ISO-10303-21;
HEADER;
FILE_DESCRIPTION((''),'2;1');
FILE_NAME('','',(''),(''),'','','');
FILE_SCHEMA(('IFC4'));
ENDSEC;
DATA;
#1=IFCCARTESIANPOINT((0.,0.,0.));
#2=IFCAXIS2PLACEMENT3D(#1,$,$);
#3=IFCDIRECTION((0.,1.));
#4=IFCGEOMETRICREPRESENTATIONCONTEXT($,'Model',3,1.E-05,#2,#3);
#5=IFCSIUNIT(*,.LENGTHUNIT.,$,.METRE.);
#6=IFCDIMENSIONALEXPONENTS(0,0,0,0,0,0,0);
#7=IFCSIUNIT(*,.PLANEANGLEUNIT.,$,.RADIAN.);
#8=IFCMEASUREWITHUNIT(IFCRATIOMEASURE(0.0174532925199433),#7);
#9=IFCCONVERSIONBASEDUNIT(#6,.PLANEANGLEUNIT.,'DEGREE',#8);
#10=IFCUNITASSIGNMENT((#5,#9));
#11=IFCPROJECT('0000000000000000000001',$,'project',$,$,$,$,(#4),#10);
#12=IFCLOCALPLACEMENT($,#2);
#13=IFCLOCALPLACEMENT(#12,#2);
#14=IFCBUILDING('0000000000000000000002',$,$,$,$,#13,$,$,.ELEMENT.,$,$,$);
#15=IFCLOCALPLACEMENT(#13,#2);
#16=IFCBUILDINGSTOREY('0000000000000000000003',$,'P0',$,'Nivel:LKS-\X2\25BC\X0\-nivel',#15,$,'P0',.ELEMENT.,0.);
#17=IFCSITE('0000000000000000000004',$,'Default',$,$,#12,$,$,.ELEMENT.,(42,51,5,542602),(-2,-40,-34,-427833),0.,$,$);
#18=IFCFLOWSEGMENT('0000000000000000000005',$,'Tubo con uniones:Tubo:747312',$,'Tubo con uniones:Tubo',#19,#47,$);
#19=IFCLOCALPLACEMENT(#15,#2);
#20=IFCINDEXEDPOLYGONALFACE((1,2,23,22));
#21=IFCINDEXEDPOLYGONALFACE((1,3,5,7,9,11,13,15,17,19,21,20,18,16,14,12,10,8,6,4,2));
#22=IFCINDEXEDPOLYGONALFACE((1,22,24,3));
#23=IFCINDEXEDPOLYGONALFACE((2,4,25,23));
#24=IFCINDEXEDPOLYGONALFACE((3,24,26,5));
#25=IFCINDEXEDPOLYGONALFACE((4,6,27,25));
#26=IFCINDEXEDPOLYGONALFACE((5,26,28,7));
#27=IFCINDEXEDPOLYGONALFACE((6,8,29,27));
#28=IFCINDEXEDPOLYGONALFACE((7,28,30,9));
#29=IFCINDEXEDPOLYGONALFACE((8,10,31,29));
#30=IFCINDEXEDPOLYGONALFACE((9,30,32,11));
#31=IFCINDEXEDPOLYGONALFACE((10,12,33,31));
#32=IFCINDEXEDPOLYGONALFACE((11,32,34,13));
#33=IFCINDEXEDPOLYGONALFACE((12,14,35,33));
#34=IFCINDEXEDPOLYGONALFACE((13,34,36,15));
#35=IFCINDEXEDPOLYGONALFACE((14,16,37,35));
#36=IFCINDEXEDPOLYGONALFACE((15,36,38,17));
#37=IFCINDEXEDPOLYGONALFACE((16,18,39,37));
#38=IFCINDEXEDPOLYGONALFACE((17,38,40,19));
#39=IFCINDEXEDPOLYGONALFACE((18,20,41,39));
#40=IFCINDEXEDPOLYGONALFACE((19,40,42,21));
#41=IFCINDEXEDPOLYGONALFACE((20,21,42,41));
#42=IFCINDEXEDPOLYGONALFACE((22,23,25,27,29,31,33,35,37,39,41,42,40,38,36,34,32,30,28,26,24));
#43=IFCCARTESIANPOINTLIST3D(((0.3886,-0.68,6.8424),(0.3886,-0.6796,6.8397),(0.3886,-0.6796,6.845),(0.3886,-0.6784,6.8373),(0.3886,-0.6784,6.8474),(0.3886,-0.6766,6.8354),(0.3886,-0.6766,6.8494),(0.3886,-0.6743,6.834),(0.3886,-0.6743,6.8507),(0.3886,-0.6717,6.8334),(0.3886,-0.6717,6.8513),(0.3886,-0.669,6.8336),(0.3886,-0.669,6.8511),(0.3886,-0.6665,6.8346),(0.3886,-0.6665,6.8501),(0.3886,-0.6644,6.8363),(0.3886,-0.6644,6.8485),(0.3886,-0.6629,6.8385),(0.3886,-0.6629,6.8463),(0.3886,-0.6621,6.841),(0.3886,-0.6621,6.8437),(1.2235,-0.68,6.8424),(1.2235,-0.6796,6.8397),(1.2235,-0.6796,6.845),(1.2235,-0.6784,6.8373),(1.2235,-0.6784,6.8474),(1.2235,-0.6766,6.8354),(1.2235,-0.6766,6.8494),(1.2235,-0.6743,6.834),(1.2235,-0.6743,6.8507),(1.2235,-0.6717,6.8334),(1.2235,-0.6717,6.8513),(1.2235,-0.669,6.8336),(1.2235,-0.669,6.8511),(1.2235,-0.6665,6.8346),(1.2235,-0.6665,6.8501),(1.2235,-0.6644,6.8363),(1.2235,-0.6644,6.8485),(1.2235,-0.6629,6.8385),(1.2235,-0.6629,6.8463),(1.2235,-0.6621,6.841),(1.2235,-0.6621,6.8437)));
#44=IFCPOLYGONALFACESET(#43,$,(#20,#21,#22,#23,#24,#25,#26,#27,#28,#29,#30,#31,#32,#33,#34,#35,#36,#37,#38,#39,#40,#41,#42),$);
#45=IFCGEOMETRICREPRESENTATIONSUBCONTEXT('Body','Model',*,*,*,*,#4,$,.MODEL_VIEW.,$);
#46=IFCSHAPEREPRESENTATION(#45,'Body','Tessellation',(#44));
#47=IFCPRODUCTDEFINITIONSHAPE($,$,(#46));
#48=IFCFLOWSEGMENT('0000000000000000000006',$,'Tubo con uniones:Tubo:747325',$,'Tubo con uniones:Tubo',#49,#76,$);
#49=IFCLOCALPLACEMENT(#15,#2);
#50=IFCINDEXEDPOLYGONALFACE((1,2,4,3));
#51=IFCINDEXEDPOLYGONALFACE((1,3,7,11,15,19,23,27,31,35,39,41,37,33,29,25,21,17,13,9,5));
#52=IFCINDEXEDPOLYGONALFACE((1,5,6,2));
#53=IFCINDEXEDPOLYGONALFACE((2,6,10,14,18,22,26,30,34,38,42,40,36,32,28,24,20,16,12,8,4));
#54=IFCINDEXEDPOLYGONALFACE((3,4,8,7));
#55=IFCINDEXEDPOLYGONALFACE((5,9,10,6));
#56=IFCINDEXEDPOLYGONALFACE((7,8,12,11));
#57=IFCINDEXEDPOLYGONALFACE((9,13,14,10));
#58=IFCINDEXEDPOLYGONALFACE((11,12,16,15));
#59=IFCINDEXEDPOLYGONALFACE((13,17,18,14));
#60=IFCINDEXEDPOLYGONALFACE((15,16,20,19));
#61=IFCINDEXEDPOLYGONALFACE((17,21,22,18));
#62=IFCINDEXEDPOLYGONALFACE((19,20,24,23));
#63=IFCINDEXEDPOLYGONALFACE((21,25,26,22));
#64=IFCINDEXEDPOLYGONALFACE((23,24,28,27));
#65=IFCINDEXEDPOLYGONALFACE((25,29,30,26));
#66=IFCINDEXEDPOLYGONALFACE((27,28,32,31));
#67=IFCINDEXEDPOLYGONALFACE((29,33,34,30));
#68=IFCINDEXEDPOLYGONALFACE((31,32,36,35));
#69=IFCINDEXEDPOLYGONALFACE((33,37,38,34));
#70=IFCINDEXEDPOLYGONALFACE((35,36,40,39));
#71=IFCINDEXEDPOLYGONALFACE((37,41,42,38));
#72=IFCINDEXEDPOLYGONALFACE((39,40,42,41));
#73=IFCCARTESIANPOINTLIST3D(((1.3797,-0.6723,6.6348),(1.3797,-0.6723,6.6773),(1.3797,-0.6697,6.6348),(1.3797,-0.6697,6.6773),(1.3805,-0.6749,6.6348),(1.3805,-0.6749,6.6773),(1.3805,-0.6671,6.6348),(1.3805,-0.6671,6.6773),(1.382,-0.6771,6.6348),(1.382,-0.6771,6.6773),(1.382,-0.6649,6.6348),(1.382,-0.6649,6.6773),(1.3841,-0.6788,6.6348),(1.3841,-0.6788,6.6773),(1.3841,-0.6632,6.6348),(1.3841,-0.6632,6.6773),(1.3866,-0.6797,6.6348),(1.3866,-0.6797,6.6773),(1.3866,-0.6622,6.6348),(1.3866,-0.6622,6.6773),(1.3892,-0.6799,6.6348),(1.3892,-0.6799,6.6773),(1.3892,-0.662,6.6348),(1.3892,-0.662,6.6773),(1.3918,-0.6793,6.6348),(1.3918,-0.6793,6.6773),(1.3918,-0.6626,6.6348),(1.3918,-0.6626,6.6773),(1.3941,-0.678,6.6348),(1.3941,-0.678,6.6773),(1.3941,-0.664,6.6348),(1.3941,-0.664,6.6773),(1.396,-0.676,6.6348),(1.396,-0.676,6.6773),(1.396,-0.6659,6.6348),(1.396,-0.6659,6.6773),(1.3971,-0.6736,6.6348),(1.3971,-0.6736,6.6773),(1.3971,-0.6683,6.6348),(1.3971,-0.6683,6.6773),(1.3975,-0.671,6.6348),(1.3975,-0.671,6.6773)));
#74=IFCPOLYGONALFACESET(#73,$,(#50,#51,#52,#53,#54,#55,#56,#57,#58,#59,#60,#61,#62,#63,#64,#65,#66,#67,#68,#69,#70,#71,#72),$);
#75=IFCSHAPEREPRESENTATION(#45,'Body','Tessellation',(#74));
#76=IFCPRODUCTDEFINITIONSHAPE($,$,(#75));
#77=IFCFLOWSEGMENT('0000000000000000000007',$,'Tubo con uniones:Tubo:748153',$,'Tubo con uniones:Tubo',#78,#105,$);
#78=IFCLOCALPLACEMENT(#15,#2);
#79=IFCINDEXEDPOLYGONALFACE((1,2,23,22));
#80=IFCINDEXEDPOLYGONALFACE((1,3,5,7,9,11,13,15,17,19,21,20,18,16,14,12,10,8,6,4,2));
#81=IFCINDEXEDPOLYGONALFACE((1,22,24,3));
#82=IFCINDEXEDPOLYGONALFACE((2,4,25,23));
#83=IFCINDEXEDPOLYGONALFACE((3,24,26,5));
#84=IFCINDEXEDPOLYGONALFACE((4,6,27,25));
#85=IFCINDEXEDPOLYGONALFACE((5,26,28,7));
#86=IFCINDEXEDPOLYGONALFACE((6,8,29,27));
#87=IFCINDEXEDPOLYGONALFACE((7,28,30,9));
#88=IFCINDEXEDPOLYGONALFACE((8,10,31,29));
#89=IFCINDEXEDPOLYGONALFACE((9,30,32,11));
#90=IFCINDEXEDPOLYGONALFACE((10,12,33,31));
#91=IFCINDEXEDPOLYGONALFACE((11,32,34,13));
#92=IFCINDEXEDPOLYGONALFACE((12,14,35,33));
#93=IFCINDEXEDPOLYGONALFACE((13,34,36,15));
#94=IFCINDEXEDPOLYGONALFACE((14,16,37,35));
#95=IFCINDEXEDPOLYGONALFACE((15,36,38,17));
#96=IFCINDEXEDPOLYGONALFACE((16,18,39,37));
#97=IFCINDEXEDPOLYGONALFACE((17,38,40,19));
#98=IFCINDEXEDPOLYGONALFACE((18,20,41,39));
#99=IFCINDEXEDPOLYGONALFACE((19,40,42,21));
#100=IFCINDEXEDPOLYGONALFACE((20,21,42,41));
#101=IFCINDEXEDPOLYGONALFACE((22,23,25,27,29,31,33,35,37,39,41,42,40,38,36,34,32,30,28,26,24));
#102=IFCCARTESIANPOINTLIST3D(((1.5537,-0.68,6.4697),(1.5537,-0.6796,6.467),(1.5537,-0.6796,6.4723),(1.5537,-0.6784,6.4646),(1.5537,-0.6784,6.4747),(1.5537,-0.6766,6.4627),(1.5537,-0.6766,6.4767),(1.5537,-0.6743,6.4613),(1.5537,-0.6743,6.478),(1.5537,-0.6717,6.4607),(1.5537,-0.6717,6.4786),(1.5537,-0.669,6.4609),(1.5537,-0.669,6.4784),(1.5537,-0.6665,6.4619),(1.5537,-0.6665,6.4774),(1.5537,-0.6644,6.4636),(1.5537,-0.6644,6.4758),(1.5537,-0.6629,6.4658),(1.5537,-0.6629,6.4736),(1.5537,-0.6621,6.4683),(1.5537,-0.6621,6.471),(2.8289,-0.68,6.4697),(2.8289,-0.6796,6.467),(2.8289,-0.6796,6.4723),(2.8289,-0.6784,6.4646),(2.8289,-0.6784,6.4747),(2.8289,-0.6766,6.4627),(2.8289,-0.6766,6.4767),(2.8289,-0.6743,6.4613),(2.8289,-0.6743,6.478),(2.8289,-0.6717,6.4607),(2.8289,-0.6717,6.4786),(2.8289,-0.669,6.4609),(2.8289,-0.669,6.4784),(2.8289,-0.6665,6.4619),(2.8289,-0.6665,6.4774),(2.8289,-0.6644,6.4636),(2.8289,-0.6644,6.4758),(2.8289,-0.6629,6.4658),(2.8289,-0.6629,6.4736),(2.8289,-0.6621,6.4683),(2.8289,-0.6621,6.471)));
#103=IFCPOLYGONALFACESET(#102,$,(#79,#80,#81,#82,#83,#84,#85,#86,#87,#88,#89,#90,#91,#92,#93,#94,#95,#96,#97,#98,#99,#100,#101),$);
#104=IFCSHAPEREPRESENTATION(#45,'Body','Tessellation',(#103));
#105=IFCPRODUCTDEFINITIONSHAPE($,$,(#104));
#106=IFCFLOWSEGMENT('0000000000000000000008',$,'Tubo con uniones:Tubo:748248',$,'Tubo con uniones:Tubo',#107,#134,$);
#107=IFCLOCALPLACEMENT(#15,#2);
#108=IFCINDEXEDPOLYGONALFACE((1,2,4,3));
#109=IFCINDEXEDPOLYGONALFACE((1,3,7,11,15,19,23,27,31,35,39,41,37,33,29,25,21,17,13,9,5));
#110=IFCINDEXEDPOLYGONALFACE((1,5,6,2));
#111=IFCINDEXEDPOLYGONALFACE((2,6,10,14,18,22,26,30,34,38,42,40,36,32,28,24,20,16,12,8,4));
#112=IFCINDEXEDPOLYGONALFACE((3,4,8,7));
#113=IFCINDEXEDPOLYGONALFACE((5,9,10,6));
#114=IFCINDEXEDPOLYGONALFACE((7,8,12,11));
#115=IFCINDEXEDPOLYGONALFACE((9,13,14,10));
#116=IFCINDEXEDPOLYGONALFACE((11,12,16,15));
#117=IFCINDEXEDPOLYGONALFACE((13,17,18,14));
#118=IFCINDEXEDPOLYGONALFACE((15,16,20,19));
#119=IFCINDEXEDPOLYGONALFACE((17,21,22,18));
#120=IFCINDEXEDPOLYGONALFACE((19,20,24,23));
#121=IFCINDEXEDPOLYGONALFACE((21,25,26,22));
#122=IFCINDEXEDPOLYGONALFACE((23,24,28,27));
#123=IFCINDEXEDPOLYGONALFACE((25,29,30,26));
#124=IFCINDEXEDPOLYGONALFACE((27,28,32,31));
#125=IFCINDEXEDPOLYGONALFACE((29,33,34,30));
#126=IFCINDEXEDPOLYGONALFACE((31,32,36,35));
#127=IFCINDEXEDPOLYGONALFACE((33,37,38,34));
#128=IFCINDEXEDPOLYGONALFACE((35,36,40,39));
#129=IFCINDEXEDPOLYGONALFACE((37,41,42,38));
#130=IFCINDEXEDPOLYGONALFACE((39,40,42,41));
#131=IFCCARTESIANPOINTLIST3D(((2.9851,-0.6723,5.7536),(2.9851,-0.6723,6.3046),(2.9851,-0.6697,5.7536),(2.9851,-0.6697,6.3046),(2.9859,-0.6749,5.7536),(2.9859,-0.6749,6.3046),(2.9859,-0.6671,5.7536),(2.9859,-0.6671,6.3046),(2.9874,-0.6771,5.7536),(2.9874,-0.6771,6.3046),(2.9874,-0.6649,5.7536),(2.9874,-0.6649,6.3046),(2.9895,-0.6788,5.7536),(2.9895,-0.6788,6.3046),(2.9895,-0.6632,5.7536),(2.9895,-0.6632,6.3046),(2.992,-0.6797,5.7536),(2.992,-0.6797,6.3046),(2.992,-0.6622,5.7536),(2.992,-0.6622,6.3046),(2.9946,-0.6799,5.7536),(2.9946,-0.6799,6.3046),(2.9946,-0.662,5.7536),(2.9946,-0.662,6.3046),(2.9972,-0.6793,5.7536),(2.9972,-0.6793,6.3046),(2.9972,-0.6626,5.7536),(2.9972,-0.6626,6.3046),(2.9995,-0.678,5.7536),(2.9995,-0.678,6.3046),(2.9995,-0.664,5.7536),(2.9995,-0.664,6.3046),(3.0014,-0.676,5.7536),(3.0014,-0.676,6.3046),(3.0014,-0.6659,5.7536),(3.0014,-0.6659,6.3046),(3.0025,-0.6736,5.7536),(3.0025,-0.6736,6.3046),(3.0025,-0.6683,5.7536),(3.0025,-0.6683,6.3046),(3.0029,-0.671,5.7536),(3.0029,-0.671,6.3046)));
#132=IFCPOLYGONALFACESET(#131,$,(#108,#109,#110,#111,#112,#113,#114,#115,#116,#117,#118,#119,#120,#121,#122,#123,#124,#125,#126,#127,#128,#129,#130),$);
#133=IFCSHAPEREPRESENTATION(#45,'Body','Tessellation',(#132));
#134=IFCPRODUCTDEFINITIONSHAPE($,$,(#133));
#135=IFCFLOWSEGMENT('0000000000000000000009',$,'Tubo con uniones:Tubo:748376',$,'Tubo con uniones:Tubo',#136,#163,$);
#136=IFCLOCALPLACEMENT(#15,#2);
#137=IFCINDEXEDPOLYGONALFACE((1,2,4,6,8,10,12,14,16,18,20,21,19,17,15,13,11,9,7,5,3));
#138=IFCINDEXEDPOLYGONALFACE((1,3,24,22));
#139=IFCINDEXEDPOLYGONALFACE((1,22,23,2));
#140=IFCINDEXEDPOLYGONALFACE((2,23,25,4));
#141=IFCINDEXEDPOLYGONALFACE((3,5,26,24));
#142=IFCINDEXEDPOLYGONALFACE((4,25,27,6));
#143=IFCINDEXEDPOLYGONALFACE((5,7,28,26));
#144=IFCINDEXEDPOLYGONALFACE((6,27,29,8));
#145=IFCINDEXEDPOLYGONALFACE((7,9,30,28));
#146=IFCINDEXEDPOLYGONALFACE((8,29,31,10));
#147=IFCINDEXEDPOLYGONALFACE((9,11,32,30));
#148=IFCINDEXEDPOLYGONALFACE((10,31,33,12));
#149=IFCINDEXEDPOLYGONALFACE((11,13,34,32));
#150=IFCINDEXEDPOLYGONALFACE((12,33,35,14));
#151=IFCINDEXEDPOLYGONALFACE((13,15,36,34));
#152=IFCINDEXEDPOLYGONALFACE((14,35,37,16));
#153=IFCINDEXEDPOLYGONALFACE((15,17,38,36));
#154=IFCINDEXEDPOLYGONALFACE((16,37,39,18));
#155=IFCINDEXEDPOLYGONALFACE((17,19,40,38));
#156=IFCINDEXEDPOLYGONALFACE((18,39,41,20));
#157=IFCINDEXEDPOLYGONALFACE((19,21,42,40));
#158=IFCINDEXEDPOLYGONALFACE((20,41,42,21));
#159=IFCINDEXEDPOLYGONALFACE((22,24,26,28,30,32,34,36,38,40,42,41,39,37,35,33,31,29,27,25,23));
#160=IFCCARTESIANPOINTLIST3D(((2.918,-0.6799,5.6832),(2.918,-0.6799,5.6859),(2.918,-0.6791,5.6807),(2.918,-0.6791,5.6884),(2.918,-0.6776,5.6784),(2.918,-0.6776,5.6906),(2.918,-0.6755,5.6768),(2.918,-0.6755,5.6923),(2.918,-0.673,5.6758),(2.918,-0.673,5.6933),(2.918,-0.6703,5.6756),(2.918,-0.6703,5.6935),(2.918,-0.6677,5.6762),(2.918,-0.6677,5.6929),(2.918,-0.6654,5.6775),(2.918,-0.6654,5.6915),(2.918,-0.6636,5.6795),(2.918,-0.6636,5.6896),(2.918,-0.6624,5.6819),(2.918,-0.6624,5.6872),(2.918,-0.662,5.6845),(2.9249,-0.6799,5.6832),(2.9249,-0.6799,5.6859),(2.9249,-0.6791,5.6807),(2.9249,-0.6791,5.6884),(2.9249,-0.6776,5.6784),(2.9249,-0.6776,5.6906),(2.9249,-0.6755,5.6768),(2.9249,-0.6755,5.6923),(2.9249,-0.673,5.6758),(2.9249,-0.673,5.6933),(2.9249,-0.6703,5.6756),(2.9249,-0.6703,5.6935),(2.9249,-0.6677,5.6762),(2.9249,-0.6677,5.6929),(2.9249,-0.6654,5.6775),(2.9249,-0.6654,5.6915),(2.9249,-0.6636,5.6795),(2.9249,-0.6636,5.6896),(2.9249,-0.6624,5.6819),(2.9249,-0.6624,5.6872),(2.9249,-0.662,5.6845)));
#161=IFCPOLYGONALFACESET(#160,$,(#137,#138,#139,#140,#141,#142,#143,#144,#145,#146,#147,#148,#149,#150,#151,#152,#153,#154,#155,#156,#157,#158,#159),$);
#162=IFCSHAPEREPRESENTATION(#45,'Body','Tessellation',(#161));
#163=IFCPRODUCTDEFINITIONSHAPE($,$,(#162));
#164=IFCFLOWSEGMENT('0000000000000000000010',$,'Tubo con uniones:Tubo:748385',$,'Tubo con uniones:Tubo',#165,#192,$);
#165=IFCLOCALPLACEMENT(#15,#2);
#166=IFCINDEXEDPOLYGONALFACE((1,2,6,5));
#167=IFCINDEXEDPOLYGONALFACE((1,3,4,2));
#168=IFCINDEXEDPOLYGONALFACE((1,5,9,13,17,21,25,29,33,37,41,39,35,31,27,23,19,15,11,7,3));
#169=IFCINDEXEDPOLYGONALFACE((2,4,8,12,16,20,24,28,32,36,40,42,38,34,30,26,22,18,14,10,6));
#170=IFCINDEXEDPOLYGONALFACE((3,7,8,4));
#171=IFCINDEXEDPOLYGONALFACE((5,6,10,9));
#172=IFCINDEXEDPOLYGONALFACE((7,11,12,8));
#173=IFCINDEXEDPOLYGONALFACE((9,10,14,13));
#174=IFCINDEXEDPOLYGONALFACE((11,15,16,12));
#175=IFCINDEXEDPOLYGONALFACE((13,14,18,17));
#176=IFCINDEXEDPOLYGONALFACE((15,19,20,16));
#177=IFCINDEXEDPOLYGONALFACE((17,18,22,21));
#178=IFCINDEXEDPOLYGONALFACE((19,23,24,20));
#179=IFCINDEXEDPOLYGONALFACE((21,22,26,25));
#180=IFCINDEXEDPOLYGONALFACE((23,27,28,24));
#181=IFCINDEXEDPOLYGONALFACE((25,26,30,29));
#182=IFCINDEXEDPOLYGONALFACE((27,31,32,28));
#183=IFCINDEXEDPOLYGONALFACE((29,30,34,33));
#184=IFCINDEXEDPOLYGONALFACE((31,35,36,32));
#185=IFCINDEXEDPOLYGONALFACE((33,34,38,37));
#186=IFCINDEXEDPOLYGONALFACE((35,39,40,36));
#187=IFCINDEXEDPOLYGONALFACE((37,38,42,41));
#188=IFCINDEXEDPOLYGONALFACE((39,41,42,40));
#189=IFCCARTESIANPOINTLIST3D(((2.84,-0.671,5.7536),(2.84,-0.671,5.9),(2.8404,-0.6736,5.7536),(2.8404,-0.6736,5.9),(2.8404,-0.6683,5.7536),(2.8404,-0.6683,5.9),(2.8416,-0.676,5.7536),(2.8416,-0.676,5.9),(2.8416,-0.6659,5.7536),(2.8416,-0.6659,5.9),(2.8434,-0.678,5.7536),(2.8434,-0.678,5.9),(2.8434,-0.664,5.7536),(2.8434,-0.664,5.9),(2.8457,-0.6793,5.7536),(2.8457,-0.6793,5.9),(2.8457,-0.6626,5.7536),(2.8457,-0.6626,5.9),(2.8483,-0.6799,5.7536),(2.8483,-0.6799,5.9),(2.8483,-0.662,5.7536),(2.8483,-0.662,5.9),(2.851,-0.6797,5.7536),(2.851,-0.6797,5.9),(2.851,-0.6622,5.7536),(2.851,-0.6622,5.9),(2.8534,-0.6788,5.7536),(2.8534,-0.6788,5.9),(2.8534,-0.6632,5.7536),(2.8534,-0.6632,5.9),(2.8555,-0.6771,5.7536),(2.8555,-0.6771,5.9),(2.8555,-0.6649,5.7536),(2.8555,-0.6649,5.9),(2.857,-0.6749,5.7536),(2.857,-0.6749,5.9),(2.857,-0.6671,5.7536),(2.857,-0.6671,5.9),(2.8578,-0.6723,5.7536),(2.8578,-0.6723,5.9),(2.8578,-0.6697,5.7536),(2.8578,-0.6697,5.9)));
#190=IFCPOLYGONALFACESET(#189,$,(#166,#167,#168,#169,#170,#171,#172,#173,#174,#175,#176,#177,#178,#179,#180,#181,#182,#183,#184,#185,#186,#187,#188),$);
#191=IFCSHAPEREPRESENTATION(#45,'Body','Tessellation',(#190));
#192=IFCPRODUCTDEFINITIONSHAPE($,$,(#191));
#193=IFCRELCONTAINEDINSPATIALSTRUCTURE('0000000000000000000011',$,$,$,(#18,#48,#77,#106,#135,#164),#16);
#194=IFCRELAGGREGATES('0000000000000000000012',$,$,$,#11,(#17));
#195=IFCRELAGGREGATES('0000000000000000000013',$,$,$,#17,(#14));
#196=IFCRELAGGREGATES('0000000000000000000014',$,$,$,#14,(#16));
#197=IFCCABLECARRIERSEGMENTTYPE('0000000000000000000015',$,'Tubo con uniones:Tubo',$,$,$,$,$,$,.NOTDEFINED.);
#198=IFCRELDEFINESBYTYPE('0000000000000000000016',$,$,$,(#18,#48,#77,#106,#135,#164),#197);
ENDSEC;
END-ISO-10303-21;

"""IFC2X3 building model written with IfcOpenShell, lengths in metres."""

from ifc_helpers import new_model, entity, si_unit, converted_unit, direction, frame, frame_2d, origin, origin_2d_with_axis, place, context, subcontext, project, spatial, circle, extrude, type_object, element, save


model = new_model("IFC2X3")

# Units and contexts
model_context = context("Model", 3, precision=1e-05, world=origin(), true_north=direction((0.0, 1.0)))
body_context = subcontext(model_context, "Body", "Model", "MODEL_VIEW")
ifc_project = project(units=[si_unit("LENGTHUNIT", "METRE"), converted_unit("PLANEANGLEUNIT", "DEGREE", entity("IfcRatioMeasure", 0.0174532925199433), si_unit("PLANEANGLEUNIT", "RADIAN"), dimensions=[0, 0, 0, 0, 0, 0, 0])], contexts=[model_context])

# Site, building, storey
site_placement = place(None, origin())
site = spatial("IfcSite", under=ifc_project, at=site_placement, Name="Default", CompositionType="ELEMENT", RefLatitude=(42, 51, 5, 542602), RefLongitude=(-2, -40, -34, -427833), RefElevation=0.0)
building_placement = place(site_placement, origin())
building = spatial("IfcBuilding", under=site, at=building_placement, CompositionType="ELEMENT")
storey_placement = place(building_placement, origin())
storey = spatial("IfcBuildingStorey", under=building, at=storey_placement, Name="P0", ObjectType="Nivel:LKS-▼-nivel", LongName="P0", CompositionType="ELEMENT", Elevation=0.0)

# Flow segments
cable_carrier_segment_type = type_object("IfcCableCarrierSegmentType", Name="Tubo con uniones:Tubo", PredefinedType="NOTDEFINED")
flow_segment_1_placement = place(storey_placement, origin())
element("IfcFlowSegment", 1, at=flow_segment_1_placement, inside=storey, type_object=cable_carrier_segment_type, Name="Tubo con uniones:Tubo:747312", ObjectType="Tubo con uniones:Tubo", context=body_context, shape_type="SweptSolid", body=[
    extrude(circle(Radius=0.009, at=origin_2d_with_axis()), frame((0.3886, -0.671, 6.8424), z_axis=(1.0, 0.0, 0.0), x_axis=(0.0, -1.0, 0.0)), (0.0, 0.0, 1.0), 0.8349),
])
flow_segment_2_placement = place(storey_placement, origin())
element("IfcFlowSegment", 2, at=flow_segment_2_placement, inside=storey, type_object=cable_carrier_segment_type, Name="Tubo con uniones:Tubo:747325", ObjectType="Tubo con uniones:Tubo", context=body_context, shape_type="SweptSolid", body=[
    extrude(circle(Radius=0.009, at=frame_2d((0.0, 0.0), x_axis=(1.0, 0.0))), frame((1.3886, -0.671, 6.6348)), (0.0, 0.0, 1.0), 0.0425),
])
flow_segment_3_placement = place(storey_placement, origin())
element("IfcFlowSegment", 3, at=flow_segment_3_placement, inside=storey, type_object=cable_carrier_segment_type, Name="Tubo con uniones:Tubo:748153", ObjectType="Tubo con uniones:Tubo", context=body_context, shape_type="SweptSolid", body=[
    extrude(circle(Radius=0.009, at=frame_2d((0.0, 0.0), x_axis=(1.0, 0.0))), frame((1.5537, -0.671, 6.4697), z_axis=(1.0, 0.0, 0.0), x_axis=(0.0, -1.0, 0.0)), (0.0, 0.0, 1.0), 1.2752),
])
flow_segment_4_placement = place(storey_placement, origin())
element("IfcFlowSegment", 4, at=flow_segment_4_placement, inside=storey, type_object=cable_carrier_segment_type, Name="Tubo con uniones:Tubo:748248", ObjectType="Tubo con uniones:Tubo", context=body_context, shape_type="SweptSolid", body=[
    extrude(circle(Radius=0.009, at=frame_2d((0.0, 0.0), x_axis=(1.0, 0.0))), frame((2.994, -0.671, 5.7536)), (0.0, 0.0, 1.0), 0.551),
])
flow_segment_5_placement = place(storey_placement, origin())
element("IfcFlowSegment", 5, at=flow_segment_5_placement, inside=storey, type_object=cable_carrier_segment_type, Name="Tubo con uniones:Tubo:748376", ObjectType="Tubo con uniones:Tubo", context=body_context, shape_type="SweptSolid", body=[
    extrude(circle(Radius=0.009, at=frame_2d((0.0, 0.0), x_axis=(1.0, 0.0))), frame((2.918, -0.671, 5.6845), z_axis=(1.0, 0.0, 0.0), x_axis=(0.0, 1.0, 0.0)), (0.0, 0.0, 1.0), 0.0069),
])
flow_segment_6_placement = place(storey_placement, origin())
element("IfcFlowSegment", 6, at=flow_segment_6_placement, inside=storey, type_object=cable_carrier_segment_type, Name="Tubo con uniones:Tubo:748385", ObjectType="Tubo con uniones:Tubo", context=body_context, shape_type="SweptSolid", body=[
    extrude(circle(Radius=0.009, at=origin_2d_with_axis()), frame((2.849, -0.671, 5.7536), z_axis=(0.0, 0.0, 1.0), x_axis=(-1.0, 0.0, 0.0)), (0.0, 0.0, 1.0), 0.1464),
])

save(model, "model.ifc")
